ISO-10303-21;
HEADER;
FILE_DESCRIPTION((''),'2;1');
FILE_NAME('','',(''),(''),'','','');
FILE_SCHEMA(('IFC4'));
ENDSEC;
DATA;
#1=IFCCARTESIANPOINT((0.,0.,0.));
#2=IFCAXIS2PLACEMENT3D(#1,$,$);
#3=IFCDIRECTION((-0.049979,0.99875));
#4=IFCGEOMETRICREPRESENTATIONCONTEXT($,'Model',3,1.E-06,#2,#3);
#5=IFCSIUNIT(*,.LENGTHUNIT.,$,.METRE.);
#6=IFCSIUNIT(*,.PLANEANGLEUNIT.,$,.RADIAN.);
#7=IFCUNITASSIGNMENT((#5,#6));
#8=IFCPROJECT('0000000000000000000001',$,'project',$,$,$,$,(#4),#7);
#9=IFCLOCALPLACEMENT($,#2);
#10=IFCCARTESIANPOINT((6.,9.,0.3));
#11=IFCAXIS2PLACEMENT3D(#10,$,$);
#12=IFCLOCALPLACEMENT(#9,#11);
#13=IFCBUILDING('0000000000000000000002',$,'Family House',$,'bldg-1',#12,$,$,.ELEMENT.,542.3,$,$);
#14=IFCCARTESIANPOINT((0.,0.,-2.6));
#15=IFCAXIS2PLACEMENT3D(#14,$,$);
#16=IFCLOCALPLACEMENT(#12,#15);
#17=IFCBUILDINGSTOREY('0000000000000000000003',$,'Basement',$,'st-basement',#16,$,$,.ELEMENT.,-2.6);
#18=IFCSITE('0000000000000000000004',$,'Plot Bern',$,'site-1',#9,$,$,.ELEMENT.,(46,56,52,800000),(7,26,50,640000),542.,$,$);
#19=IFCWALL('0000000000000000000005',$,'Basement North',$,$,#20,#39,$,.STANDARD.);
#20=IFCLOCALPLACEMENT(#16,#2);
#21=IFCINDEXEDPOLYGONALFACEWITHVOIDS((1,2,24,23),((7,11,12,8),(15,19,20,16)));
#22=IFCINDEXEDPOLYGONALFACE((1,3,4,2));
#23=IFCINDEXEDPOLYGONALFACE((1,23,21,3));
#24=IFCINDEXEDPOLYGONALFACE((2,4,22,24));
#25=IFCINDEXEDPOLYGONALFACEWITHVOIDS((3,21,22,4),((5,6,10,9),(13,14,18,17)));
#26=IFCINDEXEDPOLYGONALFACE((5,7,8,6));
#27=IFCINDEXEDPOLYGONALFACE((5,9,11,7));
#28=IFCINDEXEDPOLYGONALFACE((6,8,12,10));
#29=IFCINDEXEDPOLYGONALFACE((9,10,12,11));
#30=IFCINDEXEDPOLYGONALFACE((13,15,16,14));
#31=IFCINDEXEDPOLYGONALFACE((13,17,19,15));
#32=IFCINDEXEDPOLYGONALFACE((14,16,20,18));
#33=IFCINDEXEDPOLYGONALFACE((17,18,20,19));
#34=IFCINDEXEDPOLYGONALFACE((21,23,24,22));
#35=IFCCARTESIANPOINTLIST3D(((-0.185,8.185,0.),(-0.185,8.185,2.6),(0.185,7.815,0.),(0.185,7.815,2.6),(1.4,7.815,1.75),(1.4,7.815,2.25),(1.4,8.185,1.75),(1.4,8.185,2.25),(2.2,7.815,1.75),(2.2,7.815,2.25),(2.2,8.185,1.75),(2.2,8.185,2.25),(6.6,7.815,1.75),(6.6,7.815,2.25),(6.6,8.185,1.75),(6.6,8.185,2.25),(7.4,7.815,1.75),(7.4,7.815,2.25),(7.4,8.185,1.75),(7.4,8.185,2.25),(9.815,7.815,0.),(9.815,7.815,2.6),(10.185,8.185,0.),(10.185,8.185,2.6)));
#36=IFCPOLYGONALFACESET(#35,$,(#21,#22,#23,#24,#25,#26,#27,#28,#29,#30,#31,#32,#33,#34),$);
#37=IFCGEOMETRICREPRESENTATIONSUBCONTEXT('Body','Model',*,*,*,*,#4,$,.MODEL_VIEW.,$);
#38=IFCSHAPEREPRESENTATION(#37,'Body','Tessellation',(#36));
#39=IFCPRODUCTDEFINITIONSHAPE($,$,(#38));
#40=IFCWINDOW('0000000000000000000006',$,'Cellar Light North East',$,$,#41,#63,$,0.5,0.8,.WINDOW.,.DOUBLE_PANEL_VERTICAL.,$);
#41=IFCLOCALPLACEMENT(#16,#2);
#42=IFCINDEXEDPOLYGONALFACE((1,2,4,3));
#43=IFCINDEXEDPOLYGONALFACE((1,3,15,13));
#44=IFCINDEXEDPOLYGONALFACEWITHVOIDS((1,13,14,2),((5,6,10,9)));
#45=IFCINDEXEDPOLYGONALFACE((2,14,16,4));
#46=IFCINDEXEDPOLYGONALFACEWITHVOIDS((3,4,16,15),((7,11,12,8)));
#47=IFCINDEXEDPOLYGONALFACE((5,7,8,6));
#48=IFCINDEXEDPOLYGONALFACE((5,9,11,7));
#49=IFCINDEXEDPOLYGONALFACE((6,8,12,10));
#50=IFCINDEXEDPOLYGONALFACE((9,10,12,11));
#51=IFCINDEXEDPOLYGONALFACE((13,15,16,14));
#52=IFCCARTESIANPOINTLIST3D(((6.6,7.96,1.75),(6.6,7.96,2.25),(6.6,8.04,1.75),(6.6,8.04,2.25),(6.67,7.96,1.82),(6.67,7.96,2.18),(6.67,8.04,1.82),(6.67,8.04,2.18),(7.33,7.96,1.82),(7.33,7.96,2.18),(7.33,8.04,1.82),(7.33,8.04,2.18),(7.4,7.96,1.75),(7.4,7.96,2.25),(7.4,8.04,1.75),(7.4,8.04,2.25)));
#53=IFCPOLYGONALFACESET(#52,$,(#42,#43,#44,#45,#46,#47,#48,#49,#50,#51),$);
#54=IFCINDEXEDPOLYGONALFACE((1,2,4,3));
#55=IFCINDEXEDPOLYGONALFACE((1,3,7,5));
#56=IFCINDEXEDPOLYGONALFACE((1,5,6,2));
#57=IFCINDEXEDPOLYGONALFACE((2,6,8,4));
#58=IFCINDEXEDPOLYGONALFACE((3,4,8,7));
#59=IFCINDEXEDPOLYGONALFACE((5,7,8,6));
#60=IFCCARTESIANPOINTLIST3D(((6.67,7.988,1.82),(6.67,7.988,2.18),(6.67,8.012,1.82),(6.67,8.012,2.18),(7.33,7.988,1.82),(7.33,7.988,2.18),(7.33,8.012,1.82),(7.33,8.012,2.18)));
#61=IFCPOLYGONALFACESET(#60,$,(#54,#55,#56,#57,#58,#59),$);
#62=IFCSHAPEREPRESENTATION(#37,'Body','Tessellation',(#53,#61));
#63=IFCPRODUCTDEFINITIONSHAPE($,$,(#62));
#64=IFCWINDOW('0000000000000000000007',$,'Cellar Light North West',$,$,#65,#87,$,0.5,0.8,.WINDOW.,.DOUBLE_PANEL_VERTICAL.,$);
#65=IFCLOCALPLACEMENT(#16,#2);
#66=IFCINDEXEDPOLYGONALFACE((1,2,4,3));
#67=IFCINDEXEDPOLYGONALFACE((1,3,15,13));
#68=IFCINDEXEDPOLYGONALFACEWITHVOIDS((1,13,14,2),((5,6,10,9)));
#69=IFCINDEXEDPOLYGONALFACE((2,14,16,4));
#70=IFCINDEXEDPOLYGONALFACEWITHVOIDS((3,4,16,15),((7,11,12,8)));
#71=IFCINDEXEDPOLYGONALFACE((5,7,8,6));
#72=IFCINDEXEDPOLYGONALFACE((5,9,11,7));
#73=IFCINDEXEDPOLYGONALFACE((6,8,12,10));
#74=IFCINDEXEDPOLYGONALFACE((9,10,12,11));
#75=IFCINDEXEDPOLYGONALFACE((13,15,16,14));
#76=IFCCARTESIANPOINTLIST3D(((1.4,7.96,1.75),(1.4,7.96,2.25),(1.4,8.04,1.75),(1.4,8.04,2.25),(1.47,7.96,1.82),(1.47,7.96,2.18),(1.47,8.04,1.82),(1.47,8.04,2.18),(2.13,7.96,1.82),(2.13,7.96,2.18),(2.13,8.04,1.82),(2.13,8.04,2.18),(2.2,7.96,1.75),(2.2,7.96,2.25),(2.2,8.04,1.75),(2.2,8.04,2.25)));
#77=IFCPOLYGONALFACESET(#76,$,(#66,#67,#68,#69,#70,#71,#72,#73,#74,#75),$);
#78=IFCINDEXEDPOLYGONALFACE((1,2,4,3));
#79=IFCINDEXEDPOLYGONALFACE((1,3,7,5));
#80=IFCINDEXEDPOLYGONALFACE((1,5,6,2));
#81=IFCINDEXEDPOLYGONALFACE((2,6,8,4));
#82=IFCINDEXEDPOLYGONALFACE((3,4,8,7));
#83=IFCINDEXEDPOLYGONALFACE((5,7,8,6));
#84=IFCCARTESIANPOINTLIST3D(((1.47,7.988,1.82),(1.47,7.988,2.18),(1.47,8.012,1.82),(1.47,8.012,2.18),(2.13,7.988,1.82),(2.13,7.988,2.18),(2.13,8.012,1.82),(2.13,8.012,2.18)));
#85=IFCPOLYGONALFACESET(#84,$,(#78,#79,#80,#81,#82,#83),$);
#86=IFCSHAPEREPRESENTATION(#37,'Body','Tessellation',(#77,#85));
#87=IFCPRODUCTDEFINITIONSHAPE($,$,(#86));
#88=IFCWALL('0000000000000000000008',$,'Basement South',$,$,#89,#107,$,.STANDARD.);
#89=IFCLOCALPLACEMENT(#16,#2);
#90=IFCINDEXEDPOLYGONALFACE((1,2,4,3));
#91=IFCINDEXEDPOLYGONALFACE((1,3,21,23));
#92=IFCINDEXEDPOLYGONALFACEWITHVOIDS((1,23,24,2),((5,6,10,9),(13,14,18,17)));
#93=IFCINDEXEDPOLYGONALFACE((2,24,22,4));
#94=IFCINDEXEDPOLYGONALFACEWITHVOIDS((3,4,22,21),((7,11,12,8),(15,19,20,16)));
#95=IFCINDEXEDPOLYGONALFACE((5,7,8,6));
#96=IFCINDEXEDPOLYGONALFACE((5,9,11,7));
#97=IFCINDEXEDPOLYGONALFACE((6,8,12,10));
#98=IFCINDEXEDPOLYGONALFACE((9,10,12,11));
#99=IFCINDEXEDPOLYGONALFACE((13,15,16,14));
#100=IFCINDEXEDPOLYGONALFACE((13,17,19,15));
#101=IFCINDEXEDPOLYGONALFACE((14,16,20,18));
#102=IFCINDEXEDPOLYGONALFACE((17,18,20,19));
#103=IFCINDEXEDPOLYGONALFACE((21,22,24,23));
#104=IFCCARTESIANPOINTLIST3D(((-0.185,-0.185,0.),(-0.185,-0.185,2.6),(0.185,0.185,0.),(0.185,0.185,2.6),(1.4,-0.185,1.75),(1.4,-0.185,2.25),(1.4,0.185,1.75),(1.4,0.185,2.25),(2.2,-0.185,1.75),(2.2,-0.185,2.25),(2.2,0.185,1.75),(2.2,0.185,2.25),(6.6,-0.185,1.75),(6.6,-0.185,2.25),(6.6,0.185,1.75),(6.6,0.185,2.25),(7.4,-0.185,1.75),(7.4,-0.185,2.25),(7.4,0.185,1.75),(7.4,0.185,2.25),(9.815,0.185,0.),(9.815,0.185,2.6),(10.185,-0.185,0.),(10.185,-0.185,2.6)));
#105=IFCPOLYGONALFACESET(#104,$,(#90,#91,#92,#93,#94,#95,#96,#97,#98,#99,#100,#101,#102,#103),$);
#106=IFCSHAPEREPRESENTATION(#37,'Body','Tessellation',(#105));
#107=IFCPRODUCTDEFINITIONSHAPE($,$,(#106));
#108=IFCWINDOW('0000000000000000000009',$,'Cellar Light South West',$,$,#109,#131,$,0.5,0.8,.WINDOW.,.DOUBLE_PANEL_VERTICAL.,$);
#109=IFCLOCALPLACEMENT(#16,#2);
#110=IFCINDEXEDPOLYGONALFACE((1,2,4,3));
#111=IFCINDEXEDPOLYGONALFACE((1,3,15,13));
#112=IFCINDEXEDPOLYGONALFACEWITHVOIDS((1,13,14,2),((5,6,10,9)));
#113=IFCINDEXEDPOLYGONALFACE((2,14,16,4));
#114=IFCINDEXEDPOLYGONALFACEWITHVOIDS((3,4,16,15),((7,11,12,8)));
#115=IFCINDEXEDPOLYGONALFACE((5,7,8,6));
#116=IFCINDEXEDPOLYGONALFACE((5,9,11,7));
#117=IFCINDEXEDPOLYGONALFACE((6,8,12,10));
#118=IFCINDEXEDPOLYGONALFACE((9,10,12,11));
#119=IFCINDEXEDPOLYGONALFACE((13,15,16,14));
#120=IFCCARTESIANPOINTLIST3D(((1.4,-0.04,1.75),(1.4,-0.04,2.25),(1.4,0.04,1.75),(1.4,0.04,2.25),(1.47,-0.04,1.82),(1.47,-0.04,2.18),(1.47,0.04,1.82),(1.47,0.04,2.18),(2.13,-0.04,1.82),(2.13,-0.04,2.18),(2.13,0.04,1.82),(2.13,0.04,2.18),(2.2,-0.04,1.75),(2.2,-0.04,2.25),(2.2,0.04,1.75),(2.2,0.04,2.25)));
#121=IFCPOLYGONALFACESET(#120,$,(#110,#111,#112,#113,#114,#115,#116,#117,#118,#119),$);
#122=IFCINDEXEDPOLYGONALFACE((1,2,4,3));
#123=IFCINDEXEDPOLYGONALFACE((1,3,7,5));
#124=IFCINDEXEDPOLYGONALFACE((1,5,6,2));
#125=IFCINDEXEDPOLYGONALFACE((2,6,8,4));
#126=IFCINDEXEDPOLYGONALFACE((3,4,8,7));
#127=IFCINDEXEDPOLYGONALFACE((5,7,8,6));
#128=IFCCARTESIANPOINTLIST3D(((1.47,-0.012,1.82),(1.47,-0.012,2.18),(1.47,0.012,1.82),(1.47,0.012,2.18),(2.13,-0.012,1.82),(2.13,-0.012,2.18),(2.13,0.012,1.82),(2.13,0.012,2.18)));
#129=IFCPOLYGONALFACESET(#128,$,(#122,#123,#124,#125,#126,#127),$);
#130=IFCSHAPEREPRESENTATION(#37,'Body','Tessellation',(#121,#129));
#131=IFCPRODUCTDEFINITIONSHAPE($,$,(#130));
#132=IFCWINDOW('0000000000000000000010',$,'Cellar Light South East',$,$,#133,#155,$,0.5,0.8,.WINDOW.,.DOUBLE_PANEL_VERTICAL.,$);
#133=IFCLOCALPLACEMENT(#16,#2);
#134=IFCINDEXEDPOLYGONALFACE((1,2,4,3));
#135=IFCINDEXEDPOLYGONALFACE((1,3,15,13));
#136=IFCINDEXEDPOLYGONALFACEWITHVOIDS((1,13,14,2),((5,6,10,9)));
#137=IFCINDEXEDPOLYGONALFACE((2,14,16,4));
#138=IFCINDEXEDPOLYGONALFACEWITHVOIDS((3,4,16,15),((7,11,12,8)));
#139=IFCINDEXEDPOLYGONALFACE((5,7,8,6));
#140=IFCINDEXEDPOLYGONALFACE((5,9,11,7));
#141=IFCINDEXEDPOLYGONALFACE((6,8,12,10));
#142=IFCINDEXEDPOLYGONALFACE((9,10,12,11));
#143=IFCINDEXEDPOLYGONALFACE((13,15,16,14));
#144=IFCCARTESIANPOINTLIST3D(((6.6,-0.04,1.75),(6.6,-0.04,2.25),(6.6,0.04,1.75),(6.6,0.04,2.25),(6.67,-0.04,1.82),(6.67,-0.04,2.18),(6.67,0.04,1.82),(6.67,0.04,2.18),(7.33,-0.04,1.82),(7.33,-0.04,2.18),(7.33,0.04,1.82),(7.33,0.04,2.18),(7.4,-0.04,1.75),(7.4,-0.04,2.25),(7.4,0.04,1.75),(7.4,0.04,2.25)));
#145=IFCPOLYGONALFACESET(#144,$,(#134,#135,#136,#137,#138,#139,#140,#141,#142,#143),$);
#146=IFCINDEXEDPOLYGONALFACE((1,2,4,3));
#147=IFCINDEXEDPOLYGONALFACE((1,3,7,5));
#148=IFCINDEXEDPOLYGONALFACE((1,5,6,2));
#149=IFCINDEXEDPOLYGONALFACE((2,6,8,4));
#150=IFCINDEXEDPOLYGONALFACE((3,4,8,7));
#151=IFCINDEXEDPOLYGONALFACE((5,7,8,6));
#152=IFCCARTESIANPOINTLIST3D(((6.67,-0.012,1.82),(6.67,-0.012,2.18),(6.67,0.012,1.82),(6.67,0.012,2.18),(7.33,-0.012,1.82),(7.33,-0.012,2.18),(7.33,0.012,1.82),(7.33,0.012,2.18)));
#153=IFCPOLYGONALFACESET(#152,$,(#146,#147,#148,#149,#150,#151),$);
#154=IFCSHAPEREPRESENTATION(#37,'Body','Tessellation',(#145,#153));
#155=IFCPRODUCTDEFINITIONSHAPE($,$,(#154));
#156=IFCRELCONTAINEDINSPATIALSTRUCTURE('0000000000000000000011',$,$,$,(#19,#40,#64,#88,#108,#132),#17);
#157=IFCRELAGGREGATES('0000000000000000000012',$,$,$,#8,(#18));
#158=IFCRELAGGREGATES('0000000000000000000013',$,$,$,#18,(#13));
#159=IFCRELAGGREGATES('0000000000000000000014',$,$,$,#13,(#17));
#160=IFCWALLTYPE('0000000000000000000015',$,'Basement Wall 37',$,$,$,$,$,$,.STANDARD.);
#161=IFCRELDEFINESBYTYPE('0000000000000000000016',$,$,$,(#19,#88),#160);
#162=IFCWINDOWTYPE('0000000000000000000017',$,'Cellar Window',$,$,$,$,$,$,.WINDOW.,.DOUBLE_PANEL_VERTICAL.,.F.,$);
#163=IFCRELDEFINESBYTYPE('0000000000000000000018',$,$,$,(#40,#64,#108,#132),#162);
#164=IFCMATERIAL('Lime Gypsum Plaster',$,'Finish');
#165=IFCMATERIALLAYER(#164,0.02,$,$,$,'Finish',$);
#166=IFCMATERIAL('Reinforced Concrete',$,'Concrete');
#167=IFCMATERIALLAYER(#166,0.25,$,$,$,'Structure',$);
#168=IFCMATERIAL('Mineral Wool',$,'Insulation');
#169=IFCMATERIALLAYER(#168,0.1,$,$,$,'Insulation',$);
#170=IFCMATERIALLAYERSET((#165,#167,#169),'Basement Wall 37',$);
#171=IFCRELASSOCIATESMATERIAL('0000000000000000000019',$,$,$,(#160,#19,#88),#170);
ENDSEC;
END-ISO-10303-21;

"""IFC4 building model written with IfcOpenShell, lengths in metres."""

from ifc_helpers import new_model, si_unit, direction, frame, frame_2d, origin, origin_2d, place, context, subcontext, project, spatial, polyline, rectangle, outline, extrude, material, layer, layer_set, layer_usage, type_object, element, fill, save


model = new_model("IFC4")

# Units and contexts
model_context = context("Model", 3, precision=1e-06, world=origin(), true_north=direction((-0.049979, 0.99875)))
body_context = subcontext(model_context, "Body", "Model", "MODEL_VIEW")
ifc_project = project(units=[si_unit("LENGTHUNIT", "METRE"), si_unit("PLANEANGLEUNIT", "RADIAN")], contexts=[model_context])

# Site, building, storey
site_placement = place(None, origin())
site = spatial("IfcSite", under=ifc_project, at=site_placement, Name="Plot Bern", ObjectType="site-1", CompositionType="ELEMENT", RefLatitude=(46, 56, 52, 800000), RefLongitude=(7, 26, 50, 640000), RefElevation=542.0)
building_placement = place(site_placement, frame((6.0, 9.0, 0.3)))
building = spatial("IfcBuilding", under=site, at=building_placement, Name="Family House", ObjectType="bldg-1", CompositionType="ELEMENT", ElevationOfRefHeight=542.3)
storey_placement = place(building_placement, frame((0.0, 0.0, -2.6)))
storey = spatial("IfcBuildingStorey", under=building, at=storey_placement, Name="Basement", ObjectType="st-basement", CompositionType="ELEMENT", Elevation=-2.6)

# Shared definitions
ifc_material_1 = material(Name="Mineral Wool", Category="Insulation")
ifc_material_2 = material(Name="Reinforced Concrete", Category="Concrete")

# Shared definitions
ifc_material_3 = material(Name="Lime Gypsum Plaster", Category="Finish")
ifc_layer_1 = layer(ifc_material_3, 0.02, Category="Finish")
ifc_layer_2 = layer(ifc_material_2, 0.25, Category="Structure")
ifc_layer_3 = layer(ifc_material_1, 0.1, Category="Insulation")
ifc_layer_set_1 = layer_set([ifc_layer_1, ifc_layer_2, ifc_layer_3], Name="Basement Wall 37")
wall_type_1 = type_object("IfcWallType", Name="Basement Wall 37", PredefinedType="STANDARD", material=ifc_layer_set_1)

# Walls, openings, windows
ifc_layer_usage_1 = layer_usage(ifc_layer_set_1, "AXIS2", "NEGATIVE", 0.185)
wall_1_placement = place(storey_placement, origin())
wall_1 = element("IfcWall", 1, at=wall_1_placement, inside=storey, type_object=wall_type_1, material=ifc_layer_usage_1, Name="Basement North", PredefinedType="STANDARD", context=body_context, shape_type="SweptSolid", body=[
    extrude(outline(polyline([(10.185, 8.185), (-0.185, 8.185), (0.185, 7.815), (9.815, 7.815), (10.185, 8.185)])), origin(), (0.0, 0.0, 1.0), 2.6),
])
opening_1_placement = place(wall_1_placement, frame((7.0, 8.0, 1.75), z_axis=(0.0, 0.0, 1.0), x_axis=(-1.0, 0.0, 0.0)))
opening_1 = element("IfcOpeningElement", 2, at=opening_1_placement, cuts=wall_1, PredefinedType="OPENING", context=body_context, shape_type="SweptSolid", body=[
    extrude(rectangle(XDim=0.8, YDim=0.37, at=origin_2d()), origin(), (0.0, 0.0, 1.0), 0.5),
])
opening_2_placement = place(wall_1_placement, frame((1.8, 8.0, 1.75), z_axis=(0.0, 0.0, 1.0), x_axis=(-1.0, 0.0, 0.0)))
opening_2 = element("IfcOpeningElement", 3, at=opening_2_placement, cuts=wall_1, PredefinedType="OPENING", context=body_context, shape_type="SweptSolid", body=[
    extrude(rectangle(XDim=0.8, YDim=0.37, at=origin_2d()), origin(), (0.0, 0.0, 1.0), 0.5),
])
window_type = type_object("IfcWindowType", Name="Cellar Window", ParameterTakesPrecedence=False, PartitioningType="DOUBLE_PANEL_VERTICAL", PredefinedType="WINDOW")
window_1_placement = place(opening_1_placement, frame((0.0, 0.0, 0.0), z_axis=(0.0, -1.0, 0.0), x_axis=(1.0, 0.0, 0.0)))
window_1 = element("IfcWindow", 4, at=window_1_placement, inside=storey, type_object=window_type, Name="Cellar Light North East", OverallHeight=0.5, OverallWidth=0.8, PartitioningType="DOUBLE_PANEL_VERTICAL", PredefinedType="WINDOW", context=body_context, shape_type="SweptSolid", body=[
    extrude(outline(polyline([(-0.4, 0.0), (0.4, 0.0), (0.4, 0.5), (-0.4, 0.5), (-0.4, 0.0)]), holes=[polyline([(-0.33, 0.07), (0.33, 0.07), (0.33, 0.43), (-0.33, 0.43), (-0.33, 0.07)])]), frame((0.0, 0.0, -0.04)), (0.0, 0.0, 1.0), 0.08),
    extrude(rectangle(XDim=0.66, YDim=0.36, at=frame_2d((0.0, 0.25))), frame((0.0, 0.0, -0.012)), (0.0, 0.0, 1.0), 0.024),
])
fill(opening_1, window_1)
window_2_placement = place(opening_2_placement, frame((0.0, 0.0, 0.0), z_axis=(0.0, -1.0, 0.0), x_axis=(1.0, 0.0, 0.0)))
window_2 = element("IfcWindow", 5, at=window_2_placement, inside=storey, type_object=window_type, Name="Cellar Light North West", OverallHeight=0.5, OverallWidth=0.8, PartitioningType="DOUBLE_PANEL_VERTICAL", PredefinedType="WINDOW", context=body_context, shape_type="SweptSolid", body=[
    extrude(outline(polyline([(-0.4, 0.0), (0.4, 0.0), (0.4, 0.5), (-0.4, 0.5), (-0.4, 0.0)]), holes=[polyline([(-0.33, 0.07), (0.33, 0.07), (0.33, 0.43), (-0.33, 0.43), (-0.33, 0.07)])]), frame((0.0, 0.0, -0.04)), (0.0, 0.0, 1.0), 0.08),
    extrude(rectangle(XDim=0.66, YDim=0.36, at=frame_2d((0.0, 0.25))), frame((0.0, 0.0, -0.012)), (0.0, 0.0, 1.0), 0.024),
])
fill(opening_2, window_2)
ifc_layer_usage_2 = layer_usage(ifc_layer_set_1, "AXIS2", "NEGATIVE", 0.185)
wall_2_placement = place(storey_placement, origin())
wall_2 = element("IfcWall", 6, at=wall_2_placement, inside=storey, type_object=wall_type_1, material=ifc_layer_usage_2, Name="Basement South", PredefinedType="STANDARD", context=body_context, shape_type="SweptSolid", body=[
    extrude(outline(polyline([(-0.185, -0.185), (10.185, -0.185), (9.815, 0.185), (0.185, 0.185), (-0.185, -0.185)])), origin(), (0.0, 0.0, 1.0), 2.6),
])
opening_3_placement = place(wall_2_placement, frame((1.8, 0.0, 1.75), z_axis=(0.0, 0.0, 1.0), x_axis=(1.0, 0.0, 0.0)))
opening_3 = element("IfcOpeningElement", 7, at=opening_3_placement, cuts=wall_2, PredefinedType="OPENING", context=body_context, shape_type="SweptSolid", body=[
    extrude(rectangle(XDim=0.8, YDim=0.37, at=origin_2d()), origin(), (0.0, 0.0, 1.0), 0.5),
])
opening_4_placement = place(wall_2_placement, frame((7.0, 0.0, 1.75), z_axis=(0.0, 0.0, 1.0), x_axis=(1.0, 0.0, 0.0)))
opening_4 = element("IfcOpeningElement", 8, at=opening_4_placement, cuts=wall_2, PredefinedType="OPENING", context=body_context, shape_type="SweptSolid", body=[
    extrude(rectangle(XDim=0.8, YDim=0.37, at=origin_2d()), origin(), (0.0, 0.0, 1.0), 0.5),
])
window_3_placement = place(opening_3_placement, frame((0.0, 0.0, 0.0), z_axis=(0.0, -1.0, 0.0), x_axis=(1.0, 0.0, 0.0)))
window_3 = element("IfcWindow", 9, at=window_3_placement, inside=storey, type_object=window_type, Name="Cellar Light South West", OverallHeight=0.5, OverallWidth=0.8, PartitioningType="DOUBLE_PANEL_VERTICAL", PredefinedType="WINDOW", context=body_context, shape_type="SweptSolid", body=[
    extrude(outline(polyline([(-0.4, 0.0), (0.4, 0.0), (0.4, 0.5), (-0.4, 0.5), (-0.4, 0.0)]), holes=[polyline([(-0.33, 0.07), (0.33, 0.07), (0.33, 0.43), (-0.33, 0.43), (-0.33, 0.07)])]), frame((0.0, 0.0, -0.04)), (0.0, 0.0, 1.0), 0.08),
    extrude(rectangle(XDim=0.66, YDim=0.36, at=frame_2d((0.0, 0.25))), frame((0.0, 0.0, -0.012)), (0.0, 0.0, 1.0), 0.024),
])
fill(opening_3, window_3)
window_4_placement = place(opening_4_placement, frame((0.0, 0.0, 0.0), z_axis=(0.0, -1.0, 0.0), x_axis=(1.0, 0.0, 0.0)))
window_4 = element("IfcWindow", 10, at=window_4_placement, inside=storey, type_object=window_type, Name="Cellar Light South East", OverallHeight=0.5, OverallWidth=0.8, PartitioningType="DOUBLE_PANEL_VERTICAL", PredefinedType="WINDOW", context=body_context, shape_type="SweptSolid", body=[
    extrude(outline(polyline([(-0.4, 0.0), (0.4, 0.0), (0.4, 0.5), (-0.4, 0.5), (-0.4, 0.0)]), holes=[polyline([(-0.33, 0.07), (0.33, 0.07), (0.33, 0.43), (-0.33, 0.43), (-0.33, 0.07)])]), frame((0.0, 0.0, -0.04)), (0.0, 0.0, 1.0), 0.08),
    extrude(rectangle(XDim=0.66, YDim=0.36, at=frame_2d((0.0, 0.25))), frame((0.0, 0.0, -0.012)), (0.0, 0.0, 1.0), 0.024),
])
fill(opening_4, window_4)

save(model, "model.ifc")
